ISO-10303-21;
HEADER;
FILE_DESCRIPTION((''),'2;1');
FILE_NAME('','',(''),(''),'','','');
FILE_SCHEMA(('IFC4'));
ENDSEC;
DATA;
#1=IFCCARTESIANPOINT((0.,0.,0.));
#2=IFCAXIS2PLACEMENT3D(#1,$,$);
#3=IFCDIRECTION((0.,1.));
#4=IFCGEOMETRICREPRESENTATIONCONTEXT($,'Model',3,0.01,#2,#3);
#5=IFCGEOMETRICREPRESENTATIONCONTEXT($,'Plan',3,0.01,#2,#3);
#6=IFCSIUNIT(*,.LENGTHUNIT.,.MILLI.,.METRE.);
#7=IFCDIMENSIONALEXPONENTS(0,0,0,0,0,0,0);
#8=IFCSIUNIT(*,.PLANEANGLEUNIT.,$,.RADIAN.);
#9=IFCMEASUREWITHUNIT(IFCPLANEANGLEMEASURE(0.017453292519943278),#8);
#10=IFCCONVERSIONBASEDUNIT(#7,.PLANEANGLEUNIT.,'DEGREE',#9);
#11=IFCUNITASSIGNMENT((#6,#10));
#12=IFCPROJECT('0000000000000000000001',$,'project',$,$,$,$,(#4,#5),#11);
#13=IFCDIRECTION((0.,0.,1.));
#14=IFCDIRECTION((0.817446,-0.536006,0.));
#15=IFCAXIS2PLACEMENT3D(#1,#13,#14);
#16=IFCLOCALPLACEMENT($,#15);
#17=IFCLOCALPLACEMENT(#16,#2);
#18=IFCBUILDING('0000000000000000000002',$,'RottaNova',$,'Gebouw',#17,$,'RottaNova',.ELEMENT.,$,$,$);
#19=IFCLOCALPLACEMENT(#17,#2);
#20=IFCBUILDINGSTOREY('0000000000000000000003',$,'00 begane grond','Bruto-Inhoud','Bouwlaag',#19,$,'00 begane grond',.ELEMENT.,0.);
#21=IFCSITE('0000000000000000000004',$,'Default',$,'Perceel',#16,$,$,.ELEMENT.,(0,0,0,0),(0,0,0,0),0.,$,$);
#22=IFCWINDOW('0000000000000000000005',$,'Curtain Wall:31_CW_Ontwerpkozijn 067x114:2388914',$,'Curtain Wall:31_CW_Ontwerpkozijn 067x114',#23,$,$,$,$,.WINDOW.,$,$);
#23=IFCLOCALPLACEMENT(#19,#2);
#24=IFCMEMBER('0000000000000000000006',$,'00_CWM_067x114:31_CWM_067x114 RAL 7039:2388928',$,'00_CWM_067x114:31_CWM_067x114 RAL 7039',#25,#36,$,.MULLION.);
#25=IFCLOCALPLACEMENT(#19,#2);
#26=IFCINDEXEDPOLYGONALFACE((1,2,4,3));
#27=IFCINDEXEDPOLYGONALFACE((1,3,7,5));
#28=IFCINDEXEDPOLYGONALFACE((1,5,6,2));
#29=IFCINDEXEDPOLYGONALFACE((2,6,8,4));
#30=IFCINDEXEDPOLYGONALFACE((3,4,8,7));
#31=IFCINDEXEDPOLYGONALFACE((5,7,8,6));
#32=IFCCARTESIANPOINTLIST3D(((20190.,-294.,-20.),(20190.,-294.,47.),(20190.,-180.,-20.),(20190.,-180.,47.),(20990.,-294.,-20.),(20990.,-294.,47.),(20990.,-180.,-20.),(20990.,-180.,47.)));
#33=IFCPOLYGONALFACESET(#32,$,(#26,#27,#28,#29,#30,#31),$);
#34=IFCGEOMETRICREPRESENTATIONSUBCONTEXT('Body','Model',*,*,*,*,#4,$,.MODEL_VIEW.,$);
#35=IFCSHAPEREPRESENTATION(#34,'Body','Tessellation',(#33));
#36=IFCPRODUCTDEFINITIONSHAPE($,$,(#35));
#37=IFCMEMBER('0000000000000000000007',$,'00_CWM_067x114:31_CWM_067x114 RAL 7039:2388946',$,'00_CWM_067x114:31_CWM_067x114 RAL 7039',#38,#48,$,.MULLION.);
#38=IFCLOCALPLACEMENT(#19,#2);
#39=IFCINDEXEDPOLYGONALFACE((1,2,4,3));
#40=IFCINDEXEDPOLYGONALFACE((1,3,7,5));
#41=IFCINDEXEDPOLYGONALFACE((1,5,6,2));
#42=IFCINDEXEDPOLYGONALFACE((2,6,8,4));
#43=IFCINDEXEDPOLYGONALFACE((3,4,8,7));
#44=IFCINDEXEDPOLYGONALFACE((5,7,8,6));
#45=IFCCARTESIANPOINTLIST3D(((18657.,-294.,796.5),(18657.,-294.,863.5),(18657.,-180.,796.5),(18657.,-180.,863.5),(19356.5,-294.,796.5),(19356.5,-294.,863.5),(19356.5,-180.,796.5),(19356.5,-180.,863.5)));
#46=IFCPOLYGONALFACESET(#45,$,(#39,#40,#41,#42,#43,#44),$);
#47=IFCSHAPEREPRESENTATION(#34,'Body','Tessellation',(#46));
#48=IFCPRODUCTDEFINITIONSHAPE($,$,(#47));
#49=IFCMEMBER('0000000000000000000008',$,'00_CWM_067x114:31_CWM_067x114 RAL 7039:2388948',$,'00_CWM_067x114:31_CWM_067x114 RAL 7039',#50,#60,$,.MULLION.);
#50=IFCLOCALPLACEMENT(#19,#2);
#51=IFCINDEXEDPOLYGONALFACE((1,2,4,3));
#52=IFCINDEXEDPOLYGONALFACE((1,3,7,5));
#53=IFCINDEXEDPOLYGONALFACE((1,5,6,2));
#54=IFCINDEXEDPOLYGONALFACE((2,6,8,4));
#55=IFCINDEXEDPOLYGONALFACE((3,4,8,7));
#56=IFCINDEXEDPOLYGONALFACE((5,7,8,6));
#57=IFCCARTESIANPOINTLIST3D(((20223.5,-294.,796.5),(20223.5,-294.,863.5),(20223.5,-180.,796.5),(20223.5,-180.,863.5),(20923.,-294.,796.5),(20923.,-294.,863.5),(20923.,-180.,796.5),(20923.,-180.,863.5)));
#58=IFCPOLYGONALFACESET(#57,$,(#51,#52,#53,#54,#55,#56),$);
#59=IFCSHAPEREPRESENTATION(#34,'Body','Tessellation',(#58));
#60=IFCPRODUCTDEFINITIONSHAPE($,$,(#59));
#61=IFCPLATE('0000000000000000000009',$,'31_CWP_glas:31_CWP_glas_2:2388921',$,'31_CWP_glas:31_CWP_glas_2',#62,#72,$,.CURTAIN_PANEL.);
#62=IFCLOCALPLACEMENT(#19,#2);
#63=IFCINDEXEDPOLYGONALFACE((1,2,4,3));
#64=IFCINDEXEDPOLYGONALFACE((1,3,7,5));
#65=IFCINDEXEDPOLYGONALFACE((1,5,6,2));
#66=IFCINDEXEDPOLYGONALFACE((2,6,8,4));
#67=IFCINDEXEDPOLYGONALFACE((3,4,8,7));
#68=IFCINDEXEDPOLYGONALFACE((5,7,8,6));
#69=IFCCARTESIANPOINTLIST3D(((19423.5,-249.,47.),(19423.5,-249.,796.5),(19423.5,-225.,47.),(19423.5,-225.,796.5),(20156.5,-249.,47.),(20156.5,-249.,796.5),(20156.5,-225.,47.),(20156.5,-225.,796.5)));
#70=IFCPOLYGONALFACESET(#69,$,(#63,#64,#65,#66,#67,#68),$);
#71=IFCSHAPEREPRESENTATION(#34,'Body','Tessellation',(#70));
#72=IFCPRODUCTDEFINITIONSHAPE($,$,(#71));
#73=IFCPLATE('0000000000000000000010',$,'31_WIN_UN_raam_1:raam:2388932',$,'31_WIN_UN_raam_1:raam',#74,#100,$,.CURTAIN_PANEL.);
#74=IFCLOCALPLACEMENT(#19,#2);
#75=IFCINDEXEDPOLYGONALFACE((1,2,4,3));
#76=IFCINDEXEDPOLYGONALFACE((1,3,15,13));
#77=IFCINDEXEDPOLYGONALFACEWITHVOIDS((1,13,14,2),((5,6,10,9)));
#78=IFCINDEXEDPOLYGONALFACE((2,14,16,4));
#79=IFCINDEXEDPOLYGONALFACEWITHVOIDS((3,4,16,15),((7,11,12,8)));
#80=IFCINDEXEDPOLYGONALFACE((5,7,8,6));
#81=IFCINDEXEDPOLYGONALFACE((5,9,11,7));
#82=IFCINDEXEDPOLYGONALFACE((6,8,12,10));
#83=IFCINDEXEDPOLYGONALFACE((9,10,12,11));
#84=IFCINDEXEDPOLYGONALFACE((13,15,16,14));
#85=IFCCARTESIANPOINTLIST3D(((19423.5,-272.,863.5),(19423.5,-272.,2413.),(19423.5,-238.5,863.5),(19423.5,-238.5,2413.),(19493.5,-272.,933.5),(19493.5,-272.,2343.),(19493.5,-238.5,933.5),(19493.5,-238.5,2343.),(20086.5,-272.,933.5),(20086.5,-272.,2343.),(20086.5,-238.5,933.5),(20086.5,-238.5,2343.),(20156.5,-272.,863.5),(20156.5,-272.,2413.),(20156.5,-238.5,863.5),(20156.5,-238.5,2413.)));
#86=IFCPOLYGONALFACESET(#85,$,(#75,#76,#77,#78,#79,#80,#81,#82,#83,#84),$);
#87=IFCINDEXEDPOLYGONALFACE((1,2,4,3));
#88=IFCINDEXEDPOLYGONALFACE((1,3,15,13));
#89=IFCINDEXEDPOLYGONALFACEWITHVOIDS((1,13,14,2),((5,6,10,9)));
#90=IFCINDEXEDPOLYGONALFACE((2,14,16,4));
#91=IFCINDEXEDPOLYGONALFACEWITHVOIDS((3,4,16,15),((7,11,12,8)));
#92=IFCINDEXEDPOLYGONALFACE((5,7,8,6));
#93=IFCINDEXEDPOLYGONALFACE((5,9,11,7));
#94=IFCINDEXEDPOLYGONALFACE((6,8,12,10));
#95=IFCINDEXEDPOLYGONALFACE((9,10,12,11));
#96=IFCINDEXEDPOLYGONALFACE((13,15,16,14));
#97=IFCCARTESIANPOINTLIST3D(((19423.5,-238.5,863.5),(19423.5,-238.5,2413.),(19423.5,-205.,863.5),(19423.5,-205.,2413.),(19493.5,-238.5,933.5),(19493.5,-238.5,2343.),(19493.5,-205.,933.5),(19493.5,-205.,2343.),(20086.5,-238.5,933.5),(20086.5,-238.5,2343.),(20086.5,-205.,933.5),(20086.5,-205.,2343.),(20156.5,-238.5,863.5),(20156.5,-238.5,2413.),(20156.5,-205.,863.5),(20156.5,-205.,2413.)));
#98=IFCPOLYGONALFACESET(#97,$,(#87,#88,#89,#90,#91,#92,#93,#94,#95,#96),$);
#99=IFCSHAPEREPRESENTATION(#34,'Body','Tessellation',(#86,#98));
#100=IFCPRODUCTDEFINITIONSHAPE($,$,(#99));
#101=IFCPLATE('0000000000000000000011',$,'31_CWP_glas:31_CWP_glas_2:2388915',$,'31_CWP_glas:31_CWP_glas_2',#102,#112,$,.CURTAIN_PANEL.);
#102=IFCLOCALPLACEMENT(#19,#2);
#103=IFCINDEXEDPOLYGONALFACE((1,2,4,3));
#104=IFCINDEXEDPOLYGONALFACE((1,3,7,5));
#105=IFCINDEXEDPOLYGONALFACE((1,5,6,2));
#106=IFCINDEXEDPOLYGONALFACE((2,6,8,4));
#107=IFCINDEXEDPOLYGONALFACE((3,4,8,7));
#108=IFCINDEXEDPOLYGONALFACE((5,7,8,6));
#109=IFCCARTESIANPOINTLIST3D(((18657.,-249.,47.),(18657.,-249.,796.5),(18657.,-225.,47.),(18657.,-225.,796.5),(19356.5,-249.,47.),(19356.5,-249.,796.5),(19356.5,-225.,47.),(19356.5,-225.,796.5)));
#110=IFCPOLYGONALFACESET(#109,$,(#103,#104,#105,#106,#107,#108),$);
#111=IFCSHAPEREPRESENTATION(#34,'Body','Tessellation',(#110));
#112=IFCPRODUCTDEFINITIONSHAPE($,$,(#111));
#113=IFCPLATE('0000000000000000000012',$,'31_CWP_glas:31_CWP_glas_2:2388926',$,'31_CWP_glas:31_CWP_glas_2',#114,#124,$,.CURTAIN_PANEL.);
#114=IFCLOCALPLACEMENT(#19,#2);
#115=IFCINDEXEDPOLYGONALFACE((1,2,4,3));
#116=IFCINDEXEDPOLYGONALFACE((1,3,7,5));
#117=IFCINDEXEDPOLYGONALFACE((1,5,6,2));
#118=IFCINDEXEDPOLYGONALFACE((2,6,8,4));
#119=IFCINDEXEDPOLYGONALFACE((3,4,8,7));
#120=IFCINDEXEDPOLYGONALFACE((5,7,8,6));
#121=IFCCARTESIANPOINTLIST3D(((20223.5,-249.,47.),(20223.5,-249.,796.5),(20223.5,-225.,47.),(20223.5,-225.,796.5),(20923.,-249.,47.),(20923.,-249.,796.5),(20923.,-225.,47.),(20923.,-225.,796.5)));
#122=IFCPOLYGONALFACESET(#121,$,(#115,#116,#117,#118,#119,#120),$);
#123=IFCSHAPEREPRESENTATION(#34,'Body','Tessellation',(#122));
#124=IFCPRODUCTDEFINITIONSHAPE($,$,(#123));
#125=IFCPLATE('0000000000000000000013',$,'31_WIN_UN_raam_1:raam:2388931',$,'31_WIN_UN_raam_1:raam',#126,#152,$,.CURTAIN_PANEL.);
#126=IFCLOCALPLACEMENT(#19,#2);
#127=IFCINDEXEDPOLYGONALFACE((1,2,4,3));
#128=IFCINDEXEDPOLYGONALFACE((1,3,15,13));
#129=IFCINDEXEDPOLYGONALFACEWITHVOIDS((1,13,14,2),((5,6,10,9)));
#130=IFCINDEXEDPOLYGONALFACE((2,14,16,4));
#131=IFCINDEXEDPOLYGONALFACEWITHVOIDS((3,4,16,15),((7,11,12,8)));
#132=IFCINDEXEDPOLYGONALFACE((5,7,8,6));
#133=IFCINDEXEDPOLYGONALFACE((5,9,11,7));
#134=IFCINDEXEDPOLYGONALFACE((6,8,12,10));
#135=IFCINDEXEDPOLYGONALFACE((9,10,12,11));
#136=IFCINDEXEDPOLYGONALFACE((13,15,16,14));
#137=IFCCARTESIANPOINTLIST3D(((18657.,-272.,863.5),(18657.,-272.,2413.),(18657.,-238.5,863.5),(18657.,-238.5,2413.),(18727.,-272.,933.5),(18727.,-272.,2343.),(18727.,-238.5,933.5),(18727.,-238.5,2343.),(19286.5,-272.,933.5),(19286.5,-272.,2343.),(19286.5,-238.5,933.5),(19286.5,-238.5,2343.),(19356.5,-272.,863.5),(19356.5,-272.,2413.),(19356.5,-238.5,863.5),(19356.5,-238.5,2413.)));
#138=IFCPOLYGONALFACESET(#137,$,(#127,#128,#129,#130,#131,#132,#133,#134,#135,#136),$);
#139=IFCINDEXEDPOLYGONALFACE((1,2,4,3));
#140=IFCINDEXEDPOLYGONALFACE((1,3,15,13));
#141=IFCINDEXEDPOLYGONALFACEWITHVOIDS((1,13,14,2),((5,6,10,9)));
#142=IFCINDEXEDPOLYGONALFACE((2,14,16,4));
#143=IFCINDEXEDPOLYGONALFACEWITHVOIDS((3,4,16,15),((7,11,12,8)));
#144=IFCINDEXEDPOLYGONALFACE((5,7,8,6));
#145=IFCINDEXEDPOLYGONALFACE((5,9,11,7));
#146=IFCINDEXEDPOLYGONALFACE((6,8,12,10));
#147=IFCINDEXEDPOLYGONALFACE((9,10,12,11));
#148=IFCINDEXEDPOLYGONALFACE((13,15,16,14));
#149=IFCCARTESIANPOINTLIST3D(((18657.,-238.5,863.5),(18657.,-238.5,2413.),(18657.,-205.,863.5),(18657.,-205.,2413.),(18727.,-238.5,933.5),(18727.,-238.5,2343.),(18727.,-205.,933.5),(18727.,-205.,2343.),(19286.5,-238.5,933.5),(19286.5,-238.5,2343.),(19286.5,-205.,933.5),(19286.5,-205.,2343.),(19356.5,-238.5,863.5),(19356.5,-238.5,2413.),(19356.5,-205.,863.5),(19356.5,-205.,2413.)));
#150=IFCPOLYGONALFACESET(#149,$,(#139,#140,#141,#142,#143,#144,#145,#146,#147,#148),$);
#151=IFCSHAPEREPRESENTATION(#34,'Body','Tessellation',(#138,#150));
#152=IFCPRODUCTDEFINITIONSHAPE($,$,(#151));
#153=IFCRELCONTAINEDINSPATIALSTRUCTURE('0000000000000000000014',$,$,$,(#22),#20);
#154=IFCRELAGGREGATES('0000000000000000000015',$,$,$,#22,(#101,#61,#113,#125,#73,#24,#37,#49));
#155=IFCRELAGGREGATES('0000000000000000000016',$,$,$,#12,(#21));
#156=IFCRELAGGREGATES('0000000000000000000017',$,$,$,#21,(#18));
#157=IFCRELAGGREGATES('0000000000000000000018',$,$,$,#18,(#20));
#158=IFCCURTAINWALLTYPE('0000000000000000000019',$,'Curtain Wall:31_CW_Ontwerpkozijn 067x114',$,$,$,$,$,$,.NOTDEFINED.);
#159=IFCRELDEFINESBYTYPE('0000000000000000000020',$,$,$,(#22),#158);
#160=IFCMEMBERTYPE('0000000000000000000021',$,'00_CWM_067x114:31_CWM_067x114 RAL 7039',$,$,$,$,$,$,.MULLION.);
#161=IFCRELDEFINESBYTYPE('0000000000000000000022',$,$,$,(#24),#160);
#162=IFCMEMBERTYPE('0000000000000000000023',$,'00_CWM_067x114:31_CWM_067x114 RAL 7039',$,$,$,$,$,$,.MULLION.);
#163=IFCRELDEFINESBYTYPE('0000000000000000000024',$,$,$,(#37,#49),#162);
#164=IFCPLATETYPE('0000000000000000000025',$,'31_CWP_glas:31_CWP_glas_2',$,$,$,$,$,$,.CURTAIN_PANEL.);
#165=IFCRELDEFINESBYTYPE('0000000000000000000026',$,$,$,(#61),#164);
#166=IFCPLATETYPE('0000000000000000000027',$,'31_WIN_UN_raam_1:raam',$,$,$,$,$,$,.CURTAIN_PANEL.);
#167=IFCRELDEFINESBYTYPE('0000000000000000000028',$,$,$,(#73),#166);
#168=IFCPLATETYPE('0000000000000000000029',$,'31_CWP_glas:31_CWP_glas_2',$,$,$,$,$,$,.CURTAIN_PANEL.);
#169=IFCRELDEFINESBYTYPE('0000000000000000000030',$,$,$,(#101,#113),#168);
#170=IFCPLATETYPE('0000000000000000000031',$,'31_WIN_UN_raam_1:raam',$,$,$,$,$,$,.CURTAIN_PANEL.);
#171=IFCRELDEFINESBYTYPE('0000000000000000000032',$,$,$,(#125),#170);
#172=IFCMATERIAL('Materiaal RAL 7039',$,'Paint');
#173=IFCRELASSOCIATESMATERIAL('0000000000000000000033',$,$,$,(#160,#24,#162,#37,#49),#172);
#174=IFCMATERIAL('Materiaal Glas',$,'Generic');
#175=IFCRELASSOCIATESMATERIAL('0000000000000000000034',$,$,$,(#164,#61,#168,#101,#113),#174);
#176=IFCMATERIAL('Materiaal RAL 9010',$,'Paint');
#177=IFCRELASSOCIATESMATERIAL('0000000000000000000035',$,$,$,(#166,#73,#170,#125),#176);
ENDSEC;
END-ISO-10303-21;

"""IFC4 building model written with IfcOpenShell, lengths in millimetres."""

from ifc_helpers import new_model, entity, si_unit, converted_unit, direction, frame, origin, place, context, subcontext, project, spatial, indexed_curve, outline, extrude, source, transform, mapped, material, type_object, type_shapes, element, aggregate, save


model = new_model("IFC4")

# Units and contexts
model_context = context("Model", 3, precision=0.01, world=origin(), true_north=direction((0.0, 1.0)))
plan_context = context("Plan", 3, precision=0.01, world=origin(), true_north=direction((0.0, 1.0)))
body_context = subcontext(model_context, "Body", "Model", "MODEL_VIEW")
ifc_project = project(units=[si_unit("LENGTHUNIT", "METRE", prefix="MILLI"), converted_unit("PLANEANGLEUNIT", "DEGREE", entity("IfcPlaneAngleMeasure", 0.017453292519943278), si_unit("PLANEANGLEUNIT", "RADIAN"), dimensions=[0, 0, 0, 0, 0, 0, 0])], contexts=[model_context, plan_context])

# Site, building, storey
site_placement = place(None, frame((0.0, 0.0, 0.0), z_axis=(0.0, 0.0, 1.0), x_axis=(0.817446, -0.536006, 0.0)))
site = spatial("IfcSite", under=ifc_project, at=site_placement, Name="Default", ObjectType="Perceel", CompositionType="ELEMENT", RefLatitude=(0, 0, 0, 0), RefLongitude=(0, 0, 0, 0), RefElevation=0.0)
building_placement = place(site_placement, origin())
building = spatial("IfcBuilding", under=site, at=building_placement, Name="RottaNova", ObjectType="Gebouw", LongName="RottaNova", CompositionType="ELEMENT")
storey_placement = place(building_placement, origin())
storey = spatial("IfcBuildingStorey", under=building, at=storey_placement, Name="00 begane grond", Description="Bruto-Inhoud", ObjectType="Bouwlaag", LongName="00 begane grond", CompositionType="ELEMENT", Elevation=0.0)

# Window, members, plates
curtain_wall_type = type_object("IfcCurtainWallType", Name="Curtain Wall:31_CW_Ontwerpkozijn 067x114", PredefinedType="NOTDEFINED")
window_1_placement = place(storey_placement, origin())
window_1 = element("IfcWindow", 1, at=window_1_placement, inside=storey, type_object=curtain_wall_type, Name="Curtain Wall:31_CW_Ontwerpkozijn 067x114:2388914", ObjectType="Curtain Wall:31_CW_Ontwerpkozijn 067x114", PredefinedType="WINDOW")
ifc_material_1 = material(Name="Materiaal RAL 7039", Category="Paint")
member_type_1 = type_object("IfcMemberType", Name="00_CWM_067x114:31_CWM_067x114 RAL 7039", PredefinedType="MULLION", material=ifc_material_1)
shared_shape_1 = source(origin(), body_context, "Body", "SweptSolid", [
    extrude(outline(indexed_curve([(-33.5, -57.0), (33.5, -57.0), (33.5, 57.0), (-33.5, 57.0), (-33.5, -57.0)], self_intersect=False)), frame((-33.5, 57.0, -800.0), z_axis=(0.0, 0.0, 1.0), x_axis=(-1.0, 0.0, 0.0)), (0.0, 0.0, 1.0), 800.0),
])
type_shapes(member_type_1, [shared_shape_1])
member_1_placement = place(window_1_placement, frame((20190.0, -180.0, -20.0), z_axis=(-1.0, 0.0, 0.0), x_axis=(0.0, 0.0, -1.0)))
member_1 = element("IfcMember", 2, at=member_1_placement, type_object=member_type_1, material=ifc_material_1, Name="00_CWM_067x114:31_CWM_067x114 RAL 7039:2388928", ObjectType="00_CWM_067x114:31_CWM_067x114 RAL 7039", PredefinedType="MULLION", context=body_context, shape_type="MappedRepresentation", body=[
    mapped(shared_shape_1, transform((0.0, 0.0, 0.0), scale=1.0)),
])
member_type_2 = type_object("IfcMemberType", Name="00_CWM_067x114:31_CWM_067x114 RAL 7039", PredefinedType="MULLION", material=ifc_material_1)
shared_shape_2 = source(origin(), body_context, "Body", "SweptSolid", [
    extrude(outline(indexed_curve([(-33.5, -57.0), (33.5, -57.0), (33.5, 57.0), (-33.5, 57.0), (-33.5, -57.0)], self_intersect=False)), frame((0.0, 57.0, -699.5), z_axis=(0.0, 0.0, 1.0), x_axis=(-1.0, 0.0, 0.0)), (0.0, 0.0, 1.0), 699.5),
])
type_shapes(member_type_2, [shared_shape_2])
member_2_placement = place(window_1_placement, frame((19356.5, -180.0, 830.0), z_axis=(1.0, 0.0, 0.0), x_axis=(0.0, 0.0, 1.0)))
member_2 = element("IfcMember", 3, at=member_2_placement, type_object=member_type_2, material=ifc_material_1, Name="00_CWM_067x114:31_CWM_067x114 RAL 7039:2388946", ObjectType="00_CWM_067x114:31_CWM_067x114 RAL 7039", PredefinedType="MULLION", context=body_context, shape_type="MappedRepresentation", body=[
    mapped(shared_shape_2, transform((0.0, 0.0, 0.0), scale=1.0)),
])
member_3_placement = place(window_1_placement, frame((20923.0, -180.0, 830.0), z_axis=(1.0, 0.0, 0.0), x_axis=(0.0, 0.0, 1.0)))
member_3 = element("IfcMember", 4, at=member_3_placement, type_object=member_type_2, material=ifc_material_1, Name="00_CWM_067x114:31_CWM_067x114 RAL 7039:2388948", ObjectType="00_CWM_067x114:31_CWM_067x114 RAL 7039", PredefinedType="MULLION", context=body_context, shape_type="MappedRepresentation", body=[
    mapped(shared_shape_2, transform((0.0, 0.0, 0.0), scale=1.0)),
])
ifc_material_2 = material(Name="Materiaal Glas", Category="Generic")
plate_type_1 = type_object("IfcPlateType", Name="31_CWP_glas:31_CWP_glas_2", PredefinedType="CURTAIN_PANEL", material=ifc_material_2)
shared_shape_3 = source(origin(), body_context, "Body", "SweptSolid", [
    extrude(outline(indexed_curve([(-12.0, -366.5), (12.0, -366.5), (12.0, 366.5), (-12.0, 366.5), (-12.0, -366.5)], self_intersect=False)), frame((0.0, -57.0, 0.0), z_axis=(0.0, 0.0, 1.0), x_axis=(0.0, 1.0, 0.0)), (0.0, 0.0, 1.0), 749.5),
])
type_shapes(plate_type_1, [shared_shape_3])
plate_1_placement = place(window_1_placement, frame((19790.0, -180.0, 47.0)))
plate_1 = element("IfcPlate", 5, at=plate_1_placement, type_object=plate_type_1, material=ifc_material_2, Name="31_CWP_glas:31_CWP_glas_2:2388921", ObjectType="31_CWP_glas:31_CWP_glas_2", PredefinedType="CURTAIN_PANEL", context=body_context, shape_type="MappedRepresentation", body=[
    mapped(shared_shape_3, transform((0.0, 0.0, 0.0), scale=1.0)),
])
ifc_material_3 = material(Name="Materiaal RAL 9010", Category="Paint")
plate_type_2 = type_object("IfcPlateType", Name="31_WIN_UN_raam_1:raam", PredefinedType="CURTAIN_PANEL", material=ifc_material_3)
shared_shape_4 = source(origin(), body_context, "Body", "SweptSolid", [
    extrude(outline(indexed_curve([(-366.5, -774.8), (366.5, -774.8), (366.5, 774.8), (-366.5, 774.8), (-366.5, -774.8)], self_intersect=False), holes=[indexed_curve([(-296.5, 704.8), (296.5, 704.8), (296.5, -704.8), (-296.5, -704.8), (-296.5, 704.8)], self_intersect=False)]), frame((0.0, -92.0, 774.8), z_axis=(0.0, 1.0, 0.0), x_axis=(1.0, 0.0, 0.0)), (0.0, 0.0, 1.0), 33.5),
    extrude(outline(indexed_curve([(-366.5, -774.8), (366.5, -774.8), (366.5, 774.8), (-366.5, 774.8), (-366.5, -774.8)], self_intersect=False), holes=[indexed_curve([(-296.5, 704.7), (296.5, 704.7), (296.5, -704.8), (-296.5, -704.8), (-296.5, 704.7)], self_intersect=False)]), frame((0.0, -58.5, 774.8), z_axis=(0.0, 1.0, 0.0), x_axis=(1.0, 0.0, 0.0)), (0.0, 0.0, 1.0), 33.5),
])
type_shapes(plate_type_2, [shared_shape_4])
plate_2_placement = place(window_1_placement, frame((19790.0, -180.0, 863.5)))
plate_2 = element("IfcPlate", 6, at=plate_2_placement, type_object=plate_type_2, material=ifc_material_3, Name="31_WIN_UN_raam_1:raam:2388932", ObjectType="31_WIN_UN_raam_1:raam", PredefinedType="CURTAIN_PANEL", context=body_context, shape_type="MappedRepresentation", body=[
    mapped(shared_shape_4, transform((0.0, 0.0, 0.0), scale=1.0)),
])
plate_type_3 = type_object("IfcPlateType", Name="31_CWP_glas:31_CWP_glas_2", PredefinedType="CURTAIN_PANEL", material=ifc_material_2)
shared_shape_5 = source(origin(), body_context, "Body", "SweptSolid", [
    extrude(outline(indexed_curve([(-12.0, -349.7), (12.0, -349.7), (12.0, 349.7), (-12.0, 349.7), (-12.0, -349.7)], self_intersect=False)), frame((0.0, -57.0, 0.0), z_axis=(0.0, 0.0, 1.0), x_axis=(0.0, 1.0, 0.0)), (0.0, 0.0, 1.0), 749.5),
])
type_shapes(plate_type_3, [shared_shape_5])
plate_3_placement = place(window_1_placement, frame((19006.8, -180.0, 47.0)))
plate_3 = element("IfcPlate", 7, at=plate_3_placement, type_object=plate_type_3, material=ifc_material_2, Name="31_CWP_glas:31_CWP_glas_2:2388915", ObjectType="31_CWP_glas:31_CWP_glas_2", PredefinedType="CURTAIN_PANEL", context=body_context, shape_type="MappedRepresentation", body=[
    mapped(shared_shape_5, transform((0.0, 0.0, 0.0), scale=1.0)),
])
plate_4_placement = place(window_1_placement, frame((20573.3, -180.0, 47.0)))
plate_4 = element("IfcPlate", 8, at=plate_4_placement, type_object=plate_type_3, material=ifc_material_2, Name="31_CWP_glas:31_CWP_glas_2:2388926", ObjectType="31_CWP_glas:31_CWP_glas_2", PredefinedType="CURTAIN_PANEL", context=body_context, shape_type="MappedRepresentation", body=[
    mapped(shared_shape_5, transform((0.0, 0.0, 0.0), scale=1.0)),
])
plate_type_4 = type_object("IfcPlateType", Name="31_WIN_UN_raam_1:raam", PredefinedType="CURTAIN_PANEL", material=ifc_material_3)
shared_shape_6 = source(origin(), body_context, "Body", "SweptSolid", [
    extrude(outline(indexed_curve([(-349.7, -774.8), (349.7, -774.8), (349.7, 774.8), (-349.7, 774.8), (-349.7, -774.8)], self_intersect=False), holes=[indexed_curve([(-279.7, 704.8), (279.7, 704.8), (279.7, -704.8), (-279.7, -704.8), (-279.7, 704.8)], self_intersect=False)]), frame((0.0, -92.0, 774.8), z_axis=(0.0, 1.0, 0.0), x_axis=(1.0, 0.0, 0.0)), (0.0, 0.0, 1.0), 33.5),
    extrude(outline(indexed_curve([(-349.7, -774.8), (349.7, -774.8), (349.7, 774.8), (-349.7, 774.8), (-349.7, -774.8)], self_intersect=False), holes=[indexed_curve([(-279.7, 704.7), (279.7, 704.7), (279.7, -704.8), (-279.7, -704.8), (-279.7, 704.7)], self_intersect=False)]), frame((0.0, -58.5, 774.8), z_axis=(0.0, 1.0, 0.0), x_axis=(1.0, 0.0, 0.0)), (0.0, 0.0, 1.0), 33.5),
])
type_shapes(plate_type_4, [shared_shape_6])
plate_5_placement = place(window_1_placement, frame((19006.8, -180.0, 863.5)))
plate_5 = element("IfcPlate", 9, at=plate_5_placement, type_object=plate_type_4, material=ifc_material_3, Name="31_WIN_UN_raam_1:raam:2388931", ObjectType="31_WIN_UN_raam_1:raam", PredefinedType="CURTAIN_PANEL", context=body_context, shape_type="MappedRepresentation", body=[
    mapped(shared_shape_6, transform((0.0, 0.0, 0.0), scale=1.0)),
])
aggregate(window_1, [plate_3, plate_1, plate_4, plate_5, plate_2, member_1, member_2, member_3])

save(model, "model.ifc")
